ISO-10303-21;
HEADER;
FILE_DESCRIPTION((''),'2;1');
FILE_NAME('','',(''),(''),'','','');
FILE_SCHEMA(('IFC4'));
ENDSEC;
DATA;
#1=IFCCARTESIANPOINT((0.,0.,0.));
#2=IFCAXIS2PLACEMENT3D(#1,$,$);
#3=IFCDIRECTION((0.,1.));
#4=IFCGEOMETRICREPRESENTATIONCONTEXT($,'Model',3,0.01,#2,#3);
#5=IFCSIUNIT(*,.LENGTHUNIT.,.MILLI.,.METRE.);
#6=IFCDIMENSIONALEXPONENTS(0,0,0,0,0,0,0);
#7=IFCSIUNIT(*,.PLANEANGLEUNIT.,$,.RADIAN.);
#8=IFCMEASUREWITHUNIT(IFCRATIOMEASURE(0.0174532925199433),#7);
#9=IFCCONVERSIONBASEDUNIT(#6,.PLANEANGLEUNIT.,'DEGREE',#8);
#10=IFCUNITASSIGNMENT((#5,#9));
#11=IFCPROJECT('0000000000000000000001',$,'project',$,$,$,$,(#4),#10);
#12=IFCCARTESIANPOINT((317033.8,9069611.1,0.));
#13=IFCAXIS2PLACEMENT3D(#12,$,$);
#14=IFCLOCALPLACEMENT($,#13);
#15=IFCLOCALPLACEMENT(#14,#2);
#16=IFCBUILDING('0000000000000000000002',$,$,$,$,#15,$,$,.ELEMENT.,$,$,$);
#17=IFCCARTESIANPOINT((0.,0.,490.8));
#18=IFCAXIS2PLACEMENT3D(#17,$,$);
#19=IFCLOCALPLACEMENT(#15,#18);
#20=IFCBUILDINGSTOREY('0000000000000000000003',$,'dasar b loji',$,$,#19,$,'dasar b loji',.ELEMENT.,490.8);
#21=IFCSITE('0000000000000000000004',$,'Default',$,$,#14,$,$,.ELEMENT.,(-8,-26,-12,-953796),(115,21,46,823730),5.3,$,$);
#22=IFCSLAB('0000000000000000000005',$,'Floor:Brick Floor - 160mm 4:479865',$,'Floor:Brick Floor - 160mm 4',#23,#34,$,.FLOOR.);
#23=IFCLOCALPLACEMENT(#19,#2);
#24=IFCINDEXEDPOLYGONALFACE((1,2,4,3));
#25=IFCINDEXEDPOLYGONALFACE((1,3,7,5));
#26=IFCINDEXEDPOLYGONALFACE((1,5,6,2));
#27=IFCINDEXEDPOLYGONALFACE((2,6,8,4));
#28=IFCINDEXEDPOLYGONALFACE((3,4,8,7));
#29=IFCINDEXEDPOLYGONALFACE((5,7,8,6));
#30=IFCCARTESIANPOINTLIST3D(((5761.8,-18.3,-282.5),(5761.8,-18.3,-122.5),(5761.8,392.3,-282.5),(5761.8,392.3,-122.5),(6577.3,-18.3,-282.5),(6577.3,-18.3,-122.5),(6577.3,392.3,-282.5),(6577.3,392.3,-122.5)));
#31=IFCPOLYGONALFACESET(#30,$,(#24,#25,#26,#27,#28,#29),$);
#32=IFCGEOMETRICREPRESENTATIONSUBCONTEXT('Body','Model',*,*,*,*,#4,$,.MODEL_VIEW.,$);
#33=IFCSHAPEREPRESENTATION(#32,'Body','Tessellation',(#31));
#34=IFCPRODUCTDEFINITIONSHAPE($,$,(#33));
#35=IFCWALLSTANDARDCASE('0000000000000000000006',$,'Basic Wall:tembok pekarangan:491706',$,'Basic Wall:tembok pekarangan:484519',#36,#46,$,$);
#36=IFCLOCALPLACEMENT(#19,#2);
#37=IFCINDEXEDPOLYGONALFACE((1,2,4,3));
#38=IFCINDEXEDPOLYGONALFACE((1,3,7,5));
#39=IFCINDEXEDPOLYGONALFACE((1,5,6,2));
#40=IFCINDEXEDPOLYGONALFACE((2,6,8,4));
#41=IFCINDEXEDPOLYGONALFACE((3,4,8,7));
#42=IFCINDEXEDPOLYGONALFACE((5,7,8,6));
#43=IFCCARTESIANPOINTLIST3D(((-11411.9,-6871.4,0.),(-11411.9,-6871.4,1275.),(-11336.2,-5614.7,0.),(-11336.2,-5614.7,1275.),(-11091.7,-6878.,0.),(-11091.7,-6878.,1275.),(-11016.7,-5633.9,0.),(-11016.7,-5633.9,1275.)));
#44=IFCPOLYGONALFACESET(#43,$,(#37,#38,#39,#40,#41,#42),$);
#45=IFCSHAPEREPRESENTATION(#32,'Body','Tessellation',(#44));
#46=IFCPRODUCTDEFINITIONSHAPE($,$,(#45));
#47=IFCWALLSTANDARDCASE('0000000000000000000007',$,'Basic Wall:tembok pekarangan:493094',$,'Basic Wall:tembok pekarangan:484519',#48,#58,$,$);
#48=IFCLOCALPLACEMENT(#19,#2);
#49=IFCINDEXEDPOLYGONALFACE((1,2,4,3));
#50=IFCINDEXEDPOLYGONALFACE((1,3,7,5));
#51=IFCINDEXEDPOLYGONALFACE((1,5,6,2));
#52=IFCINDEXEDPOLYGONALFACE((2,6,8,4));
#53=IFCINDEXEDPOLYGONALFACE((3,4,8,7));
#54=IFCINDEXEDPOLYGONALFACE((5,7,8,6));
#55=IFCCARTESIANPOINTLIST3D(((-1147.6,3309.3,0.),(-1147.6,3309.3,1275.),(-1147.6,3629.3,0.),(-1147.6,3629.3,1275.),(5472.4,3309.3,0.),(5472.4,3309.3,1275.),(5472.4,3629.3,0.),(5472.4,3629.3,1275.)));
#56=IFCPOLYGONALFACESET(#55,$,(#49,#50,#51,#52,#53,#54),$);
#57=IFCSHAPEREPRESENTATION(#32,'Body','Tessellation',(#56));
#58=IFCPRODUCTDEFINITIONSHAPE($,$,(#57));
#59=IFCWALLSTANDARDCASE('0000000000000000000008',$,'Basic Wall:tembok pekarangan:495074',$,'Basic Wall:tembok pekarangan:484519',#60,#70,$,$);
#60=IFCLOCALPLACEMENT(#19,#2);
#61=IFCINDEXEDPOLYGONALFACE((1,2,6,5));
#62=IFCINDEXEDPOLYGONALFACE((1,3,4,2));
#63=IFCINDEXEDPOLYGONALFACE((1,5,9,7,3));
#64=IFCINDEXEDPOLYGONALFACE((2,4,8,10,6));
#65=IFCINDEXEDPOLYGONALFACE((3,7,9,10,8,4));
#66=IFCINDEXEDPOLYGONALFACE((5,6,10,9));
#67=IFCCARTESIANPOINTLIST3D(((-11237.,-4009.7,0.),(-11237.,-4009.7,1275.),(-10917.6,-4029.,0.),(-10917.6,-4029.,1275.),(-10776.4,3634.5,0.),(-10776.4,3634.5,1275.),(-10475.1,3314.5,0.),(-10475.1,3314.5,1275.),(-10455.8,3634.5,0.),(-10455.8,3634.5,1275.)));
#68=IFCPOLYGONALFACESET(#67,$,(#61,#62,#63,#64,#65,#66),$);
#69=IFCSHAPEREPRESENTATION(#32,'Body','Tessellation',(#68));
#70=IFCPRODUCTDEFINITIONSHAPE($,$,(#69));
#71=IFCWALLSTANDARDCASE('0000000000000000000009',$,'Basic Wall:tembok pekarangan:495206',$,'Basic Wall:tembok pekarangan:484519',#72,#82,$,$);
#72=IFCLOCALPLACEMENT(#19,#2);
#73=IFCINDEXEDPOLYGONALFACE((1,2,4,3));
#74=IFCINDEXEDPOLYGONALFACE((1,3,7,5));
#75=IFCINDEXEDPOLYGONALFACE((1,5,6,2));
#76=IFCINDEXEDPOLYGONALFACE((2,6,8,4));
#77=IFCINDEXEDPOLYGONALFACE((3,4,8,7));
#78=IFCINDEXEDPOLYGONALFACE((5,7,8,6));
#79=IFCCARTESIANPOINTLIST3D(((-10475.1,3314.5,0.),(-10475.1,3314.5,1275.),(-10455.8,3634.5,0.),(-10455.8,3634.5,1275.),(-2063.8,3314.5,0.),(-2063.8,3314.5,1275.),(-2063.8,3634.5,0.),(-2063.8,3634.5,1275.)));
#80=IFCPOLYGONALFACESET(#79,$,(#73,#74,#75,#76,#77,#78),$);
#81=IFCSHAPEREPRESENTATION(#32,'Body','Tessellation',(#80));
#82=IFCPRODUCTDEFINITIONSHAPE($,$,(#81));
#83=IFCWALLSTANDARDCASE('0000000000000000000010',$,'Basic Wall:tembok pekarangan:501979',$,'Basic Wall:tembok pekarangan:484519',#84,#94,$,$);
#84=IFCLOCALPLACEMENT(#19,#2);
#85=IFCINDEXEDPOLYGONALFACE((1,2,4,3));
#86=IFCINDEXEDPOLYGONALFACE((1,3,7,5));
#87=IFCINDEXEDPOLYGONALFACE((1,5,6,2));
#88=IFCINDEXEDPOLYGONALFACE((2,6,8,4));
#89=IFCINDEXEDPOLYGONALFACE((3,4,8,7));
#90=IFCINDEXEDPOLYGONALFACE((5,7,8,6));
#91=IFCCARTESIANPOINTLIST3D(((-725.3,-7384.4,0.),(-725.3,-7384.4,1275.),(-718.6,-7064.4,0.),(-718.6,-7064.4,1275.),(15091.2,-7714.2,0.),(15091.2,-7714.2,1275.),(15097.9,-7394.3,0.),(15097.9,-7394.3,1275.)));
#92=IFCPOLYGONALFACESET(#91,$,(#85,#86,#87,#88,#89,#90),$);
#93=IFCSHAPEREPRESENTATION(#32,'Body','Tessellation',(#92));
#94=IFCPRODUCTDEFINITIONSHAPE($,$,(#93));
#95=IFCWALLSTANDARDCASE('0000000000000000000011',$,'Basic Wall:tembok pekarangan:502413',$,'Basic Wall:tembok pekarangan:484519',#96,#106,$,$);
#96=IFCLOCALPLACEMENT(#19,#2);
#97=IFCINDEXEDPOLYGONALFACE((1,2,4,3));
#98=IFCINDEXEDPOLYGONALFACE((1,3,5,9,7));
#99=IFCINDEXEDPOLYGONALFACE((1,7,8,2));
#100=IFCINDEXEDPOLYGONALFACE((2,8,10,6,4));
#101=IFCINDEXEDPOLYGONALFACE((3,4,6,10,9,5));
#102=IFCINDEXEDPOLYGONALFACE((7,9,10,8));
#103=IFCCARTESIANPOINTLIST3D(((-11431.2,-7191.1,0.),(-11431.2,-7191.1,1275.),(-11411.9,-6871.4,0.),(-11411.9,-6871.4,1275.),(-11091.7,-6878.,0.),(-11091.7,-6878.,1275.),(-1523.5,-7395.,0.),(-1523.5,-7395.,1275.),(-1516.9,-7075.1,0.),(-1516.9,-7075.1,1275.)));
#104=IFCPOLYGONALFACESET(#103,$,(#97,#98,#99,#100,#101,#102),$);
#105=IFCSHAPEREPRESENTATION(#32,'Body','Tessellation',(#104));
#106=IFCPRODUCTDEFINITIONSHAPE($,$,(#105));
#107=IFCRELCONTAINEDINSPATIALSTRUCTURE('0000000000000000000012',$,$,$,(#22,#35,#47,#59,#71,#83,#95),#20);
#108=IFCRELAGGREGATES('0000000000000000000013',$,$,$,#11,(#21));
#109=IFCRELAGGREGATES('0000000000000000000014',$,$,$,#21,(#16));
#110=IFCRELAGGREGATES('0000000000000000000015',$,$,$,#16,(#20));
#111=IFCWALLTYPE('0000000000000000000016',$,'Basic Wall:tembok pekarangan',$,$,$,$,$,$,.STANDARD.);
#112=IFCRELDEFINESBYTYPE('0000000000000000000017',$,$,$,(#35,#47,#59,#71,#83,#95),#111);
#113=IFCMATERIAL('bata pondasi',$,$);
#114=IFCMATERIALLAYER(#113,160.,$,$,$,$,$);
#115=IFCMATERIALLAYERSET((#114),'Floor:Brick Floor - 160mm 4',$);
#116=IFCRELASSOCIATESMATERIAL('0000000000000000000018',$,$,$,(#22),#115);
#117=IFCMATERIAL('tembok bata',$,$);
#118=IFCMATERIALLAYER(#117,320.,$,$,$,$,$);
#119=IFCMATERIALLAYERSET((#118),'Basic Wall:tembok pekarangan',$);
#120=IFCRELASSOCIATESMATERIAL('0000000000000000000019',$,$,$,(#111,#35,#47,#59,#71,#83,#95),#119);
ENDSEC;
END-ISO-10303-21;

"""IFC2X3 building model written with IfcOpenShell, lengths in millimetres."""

from ifc_helpers import new_model, entity, si_unit, converted_unit, direction, frame, frame_2d, origin, place, context, subcontext, project, spatial, polyline, rectangle, outline, extrude, material, layer, layer_set, layer_usage, type_object, element, save


model = new_model("IFC2X3")

# Units and contexts
model_context = context("Model", 3, precision=0.01, world=origin(), true_north=direction((0.0, 1.0)))
body_context = subcontext(model_context, "Body", "Model", "MODEL_VIEW")
ifc_project = project(units=[si_unit("LENGTHUNIT", "METRE", prefix="MILLI"), converted_unit("PLANEANGLEUNIT", "DEGREE", entity("IfcRatioMeasure", 0.0174532925199433), si_unit("PLANEANGLEUNIT", "RADIAN"), dimensions=[0, 0, 0, 0, 0, 0, 0])], contexts=[model_context])

# Site, building, storey
site_placement = place(None, frame((317033.8, 9069611.1, 0.0)))
site = spatial("IfcSite", under=ifc_project, at=site_placement, Name="Default", CompositionType="ELEMENT", RefLatitude=(-8, -26, -12, -953796), RefLongitude=(115, 21, 46, 823730), RefElevation=5.3)
building_placement = place(site_placement, origin())
building = spatial("IfcBuilding", under=site, at=building_placement, CompositionType="ELEMENT")
storey_placement = place(building_placement, frame((0.0, 0.0, 490.8)))
storey = spatial("IfcBuildingStorey", under=building, at=storey_placement, Name="dasar b loji", LongName="dasar b loji", CompositionType="ELEMENT", Elevation=490.8)

# Slab
ifc_material_1 = material(Name="bata pondasi")
ifc_layer_1 = layer(ifc_material_1, 160.0)
ifc_layer_set_1 = layer_set([ifc_layer_1], Name="Floor:Brick Floor - 160mm 4")
ifc_layer_usage_1 = layer_usage(ifc_layer_set_1, "AXIS3", "POSITIVE", 0.0)
slab_1_placement = place(storey_placement, origin())
element("IfcSlab", 1, at=slab_1_placement, inside=storey, material=ifc_layer_usage_1, Name="Floor:Brick Floor - 160mm 4:479865", ObjectType="Floor:Brick Floor - 160mm 4", PredefinedType="FLOOR", context=body_context, shape_type="SweptSolid", body=[
    extrude(rectangle(XDim=410.6, YDim=815.5, at=frame_2d((0.0, 0.0), x_axis=(1.0, 0.0))), frame((6169.6, 187.0, -122.5), z_axis=(0.0, 0.0, -1.0), x_axis=(0.0, 1.0, 0.0)), (0.0, 0.0, 1.0), 160.0),
])

# Walls
ifc_material_2 = material(Name="tembok bata")
ifc_layer_2 = layer(ifc_material_2, 320.0)
ifc_layer_set_2 = layer_set([ifc_layer_2], Name="Basic Wall:tembok pekarangan")
ifc_layer_usage_2 = layer_usage(ifc_layer_set_2, "AXIS2", "NEGATIVE", 160.0)
wall_type = type_object("IfcWallType", Name="Basic Wall:tembok pekarangan", PredefinedType="STANDARD", material=ifc_layer_set_2)
wall_1_placement = place(storey_placement, frame((-11176.4, -5624.3, 0.0), z_axis=(0.0, 0.0, 1.0), x_axis=(-0.060152, -0.998189, 0.0)))
element("IfcWallStandardCase", 2, at=wall_1_placement, inside=storey, type_object=wall_type, material=ifc_layer_usage_2, Name="Basic Wall:tembok pekarangan:491706", ObjectType="Basic Wall:tembok pekarangan:484519", context=body_context, shape_type="SweptSolid", body=[
    extrude(outline(polyline([(1259.0, -160.0), (1246.3, 160.0), (0.0, 160.0), (0.0, -160.0), (1259.0, -160.0)])), origin(), (0.0, 0.0, 1.0), 1275.0),
])
ifc_layer_usage_3 = layer_usage(ifc_layer_set_2, "AXIS2", "NEGATIVE", 160.0)
wall_2_placement = place(storey_placement, frame((-1147.6, 3469.3, 0.0)))
element("IfcWallStandardCase", 3, at=wall_2_placement, inside=storey, type_object=wall_type, material=ifc_layer_usage_3, Name="Basic Wall:tembok pekarangan:493094", ObjectType="Basic Wall:tembok pekarangan:484519", context=body_context, shape_type="SweptSolid", body=[
    extrude(rectangle(XDim=6620.0, YDim=320.0, at=frame_2d((3310.0, 0.0), x_axis=(-1.0, 0.0))), origin(), (0.0, 0.0, 1.0), 1275.0),
])
ifc_layer_usage_4 = layer_usage(ifc_layer_set_2, "AXIS2", "NEGATIVE", 160.0)
wall_3_placement = place(storey_placement, frame((-11077.3, -4019.4, 0.0), z_axis=(0.0, 0.0, 1.0), x_axis=(0.060152, 0.998189, 0.0)))
element("IfcWallStandardCase", 4, at=wall_3_placement, inside=storey, type_object=wall_type, material=ifc_layer_usage_4, Name="Basic Wall:tembok pekarangan:495074", ObjectType="Basic Wall:tembok pekarangan:484519", context=body_context, shape_type="SweptSolid", body=[
    extrude(outline(polyline([(7677.4, -160.0), (7658.1, 160.0), (0.0, 160.0), (0.0, -160.0), (7356.8, -160.0), (7677.4, -160.0)])), origin(), (0.0, 0.0, 1.0), 1275.0),
])
ifc_layer_usage_5 = layer_usage(ifc_layer_set_2, "AXIS2", "NEGATIVE", 160.0)
wall_4_placement = place(storey_placement, frame((-10475.1, 3474.5, 0.0)))
element("IfcWallStandardCase", 5, at=wall_4_placement, inside=storey, type_object=wall_type, material=ifc_layer_usage_5, Name="Basic Wall:tembok pekarangan:495206", ObjectType="Basic Wall:tembok pekarangan:484519", context=body_context, shape_type="SweptSolid", body=[
    extrude(outline(polyline([(8411.3, -160.0), (8411.3, 160.0), (19.3, 160.0), (0.0, -160.0), (8411.3, -160.0)])), origin(), (0.0, 0.0, 1.0), 1275.0),
])
ifc_layer_usage_6 = layer_usage(ifc_layer_set_2, "AXIS2", "NEGATIVE", 160.0)
wall_5_placement = place(storey_placement, frame((15094.6, -7554.2, 0.0), z_axis=(0.0, 0.0, 1.0), x_axis=(-0.999783, 0.02085, 0.0)))
element("IfcWallStandardCase", 6, at=wall_5_placement, inside=storey, type_object=wall_type, material=ifc_layer_usage_6, Name="Basic Wall:tembok pekarangan:501979", ObjectType="Basic Wall:tembok pekarangan:484519", context=body_context, shape_type="SweptSolid", body=[
    extrude(rectangle(XDim=15820.0, YDim=320.0, at=frame_2d((7910.0, 0.0), x_axis=(-1.0, 0.0))), origin(), (0.0, 0.0, 1.0), 1275.0),
])
ifc_layer_usage_7 = layer_usage(ifc_layer_set_2, "AXIS2", "NEGATIVE", 160.0)
wall_6_placement = place(storey_placement, frame((-1520.2, -7235.0, 0.0), z_axis=(0.0, 0.0, 1.0), x_axis=(-0.999788, 0.020581, 0.0)))
element("IfcWallStandardCase", 7, at=wall_6_placement, inside=storey, type_object=wall_type, material=ifc_layer_usage_7, Name="Basic Wall:tembok pekarangan:502413", ObjectType="Basic Wall:tembok pekarangan:484519", context=body_context, shape_type="SweptSolid", body=[
    extrude(outline(polyline([(9897.1, -160.0), (9909.8, 160.0), (0.0, 160.0), (0.0, -160.0), (9576.8, -160.0), (9897.1, -160.0)])), origin(), (0.0, 0.0, 1.0), 1275.0),
])

save(model, "model.ifc")
